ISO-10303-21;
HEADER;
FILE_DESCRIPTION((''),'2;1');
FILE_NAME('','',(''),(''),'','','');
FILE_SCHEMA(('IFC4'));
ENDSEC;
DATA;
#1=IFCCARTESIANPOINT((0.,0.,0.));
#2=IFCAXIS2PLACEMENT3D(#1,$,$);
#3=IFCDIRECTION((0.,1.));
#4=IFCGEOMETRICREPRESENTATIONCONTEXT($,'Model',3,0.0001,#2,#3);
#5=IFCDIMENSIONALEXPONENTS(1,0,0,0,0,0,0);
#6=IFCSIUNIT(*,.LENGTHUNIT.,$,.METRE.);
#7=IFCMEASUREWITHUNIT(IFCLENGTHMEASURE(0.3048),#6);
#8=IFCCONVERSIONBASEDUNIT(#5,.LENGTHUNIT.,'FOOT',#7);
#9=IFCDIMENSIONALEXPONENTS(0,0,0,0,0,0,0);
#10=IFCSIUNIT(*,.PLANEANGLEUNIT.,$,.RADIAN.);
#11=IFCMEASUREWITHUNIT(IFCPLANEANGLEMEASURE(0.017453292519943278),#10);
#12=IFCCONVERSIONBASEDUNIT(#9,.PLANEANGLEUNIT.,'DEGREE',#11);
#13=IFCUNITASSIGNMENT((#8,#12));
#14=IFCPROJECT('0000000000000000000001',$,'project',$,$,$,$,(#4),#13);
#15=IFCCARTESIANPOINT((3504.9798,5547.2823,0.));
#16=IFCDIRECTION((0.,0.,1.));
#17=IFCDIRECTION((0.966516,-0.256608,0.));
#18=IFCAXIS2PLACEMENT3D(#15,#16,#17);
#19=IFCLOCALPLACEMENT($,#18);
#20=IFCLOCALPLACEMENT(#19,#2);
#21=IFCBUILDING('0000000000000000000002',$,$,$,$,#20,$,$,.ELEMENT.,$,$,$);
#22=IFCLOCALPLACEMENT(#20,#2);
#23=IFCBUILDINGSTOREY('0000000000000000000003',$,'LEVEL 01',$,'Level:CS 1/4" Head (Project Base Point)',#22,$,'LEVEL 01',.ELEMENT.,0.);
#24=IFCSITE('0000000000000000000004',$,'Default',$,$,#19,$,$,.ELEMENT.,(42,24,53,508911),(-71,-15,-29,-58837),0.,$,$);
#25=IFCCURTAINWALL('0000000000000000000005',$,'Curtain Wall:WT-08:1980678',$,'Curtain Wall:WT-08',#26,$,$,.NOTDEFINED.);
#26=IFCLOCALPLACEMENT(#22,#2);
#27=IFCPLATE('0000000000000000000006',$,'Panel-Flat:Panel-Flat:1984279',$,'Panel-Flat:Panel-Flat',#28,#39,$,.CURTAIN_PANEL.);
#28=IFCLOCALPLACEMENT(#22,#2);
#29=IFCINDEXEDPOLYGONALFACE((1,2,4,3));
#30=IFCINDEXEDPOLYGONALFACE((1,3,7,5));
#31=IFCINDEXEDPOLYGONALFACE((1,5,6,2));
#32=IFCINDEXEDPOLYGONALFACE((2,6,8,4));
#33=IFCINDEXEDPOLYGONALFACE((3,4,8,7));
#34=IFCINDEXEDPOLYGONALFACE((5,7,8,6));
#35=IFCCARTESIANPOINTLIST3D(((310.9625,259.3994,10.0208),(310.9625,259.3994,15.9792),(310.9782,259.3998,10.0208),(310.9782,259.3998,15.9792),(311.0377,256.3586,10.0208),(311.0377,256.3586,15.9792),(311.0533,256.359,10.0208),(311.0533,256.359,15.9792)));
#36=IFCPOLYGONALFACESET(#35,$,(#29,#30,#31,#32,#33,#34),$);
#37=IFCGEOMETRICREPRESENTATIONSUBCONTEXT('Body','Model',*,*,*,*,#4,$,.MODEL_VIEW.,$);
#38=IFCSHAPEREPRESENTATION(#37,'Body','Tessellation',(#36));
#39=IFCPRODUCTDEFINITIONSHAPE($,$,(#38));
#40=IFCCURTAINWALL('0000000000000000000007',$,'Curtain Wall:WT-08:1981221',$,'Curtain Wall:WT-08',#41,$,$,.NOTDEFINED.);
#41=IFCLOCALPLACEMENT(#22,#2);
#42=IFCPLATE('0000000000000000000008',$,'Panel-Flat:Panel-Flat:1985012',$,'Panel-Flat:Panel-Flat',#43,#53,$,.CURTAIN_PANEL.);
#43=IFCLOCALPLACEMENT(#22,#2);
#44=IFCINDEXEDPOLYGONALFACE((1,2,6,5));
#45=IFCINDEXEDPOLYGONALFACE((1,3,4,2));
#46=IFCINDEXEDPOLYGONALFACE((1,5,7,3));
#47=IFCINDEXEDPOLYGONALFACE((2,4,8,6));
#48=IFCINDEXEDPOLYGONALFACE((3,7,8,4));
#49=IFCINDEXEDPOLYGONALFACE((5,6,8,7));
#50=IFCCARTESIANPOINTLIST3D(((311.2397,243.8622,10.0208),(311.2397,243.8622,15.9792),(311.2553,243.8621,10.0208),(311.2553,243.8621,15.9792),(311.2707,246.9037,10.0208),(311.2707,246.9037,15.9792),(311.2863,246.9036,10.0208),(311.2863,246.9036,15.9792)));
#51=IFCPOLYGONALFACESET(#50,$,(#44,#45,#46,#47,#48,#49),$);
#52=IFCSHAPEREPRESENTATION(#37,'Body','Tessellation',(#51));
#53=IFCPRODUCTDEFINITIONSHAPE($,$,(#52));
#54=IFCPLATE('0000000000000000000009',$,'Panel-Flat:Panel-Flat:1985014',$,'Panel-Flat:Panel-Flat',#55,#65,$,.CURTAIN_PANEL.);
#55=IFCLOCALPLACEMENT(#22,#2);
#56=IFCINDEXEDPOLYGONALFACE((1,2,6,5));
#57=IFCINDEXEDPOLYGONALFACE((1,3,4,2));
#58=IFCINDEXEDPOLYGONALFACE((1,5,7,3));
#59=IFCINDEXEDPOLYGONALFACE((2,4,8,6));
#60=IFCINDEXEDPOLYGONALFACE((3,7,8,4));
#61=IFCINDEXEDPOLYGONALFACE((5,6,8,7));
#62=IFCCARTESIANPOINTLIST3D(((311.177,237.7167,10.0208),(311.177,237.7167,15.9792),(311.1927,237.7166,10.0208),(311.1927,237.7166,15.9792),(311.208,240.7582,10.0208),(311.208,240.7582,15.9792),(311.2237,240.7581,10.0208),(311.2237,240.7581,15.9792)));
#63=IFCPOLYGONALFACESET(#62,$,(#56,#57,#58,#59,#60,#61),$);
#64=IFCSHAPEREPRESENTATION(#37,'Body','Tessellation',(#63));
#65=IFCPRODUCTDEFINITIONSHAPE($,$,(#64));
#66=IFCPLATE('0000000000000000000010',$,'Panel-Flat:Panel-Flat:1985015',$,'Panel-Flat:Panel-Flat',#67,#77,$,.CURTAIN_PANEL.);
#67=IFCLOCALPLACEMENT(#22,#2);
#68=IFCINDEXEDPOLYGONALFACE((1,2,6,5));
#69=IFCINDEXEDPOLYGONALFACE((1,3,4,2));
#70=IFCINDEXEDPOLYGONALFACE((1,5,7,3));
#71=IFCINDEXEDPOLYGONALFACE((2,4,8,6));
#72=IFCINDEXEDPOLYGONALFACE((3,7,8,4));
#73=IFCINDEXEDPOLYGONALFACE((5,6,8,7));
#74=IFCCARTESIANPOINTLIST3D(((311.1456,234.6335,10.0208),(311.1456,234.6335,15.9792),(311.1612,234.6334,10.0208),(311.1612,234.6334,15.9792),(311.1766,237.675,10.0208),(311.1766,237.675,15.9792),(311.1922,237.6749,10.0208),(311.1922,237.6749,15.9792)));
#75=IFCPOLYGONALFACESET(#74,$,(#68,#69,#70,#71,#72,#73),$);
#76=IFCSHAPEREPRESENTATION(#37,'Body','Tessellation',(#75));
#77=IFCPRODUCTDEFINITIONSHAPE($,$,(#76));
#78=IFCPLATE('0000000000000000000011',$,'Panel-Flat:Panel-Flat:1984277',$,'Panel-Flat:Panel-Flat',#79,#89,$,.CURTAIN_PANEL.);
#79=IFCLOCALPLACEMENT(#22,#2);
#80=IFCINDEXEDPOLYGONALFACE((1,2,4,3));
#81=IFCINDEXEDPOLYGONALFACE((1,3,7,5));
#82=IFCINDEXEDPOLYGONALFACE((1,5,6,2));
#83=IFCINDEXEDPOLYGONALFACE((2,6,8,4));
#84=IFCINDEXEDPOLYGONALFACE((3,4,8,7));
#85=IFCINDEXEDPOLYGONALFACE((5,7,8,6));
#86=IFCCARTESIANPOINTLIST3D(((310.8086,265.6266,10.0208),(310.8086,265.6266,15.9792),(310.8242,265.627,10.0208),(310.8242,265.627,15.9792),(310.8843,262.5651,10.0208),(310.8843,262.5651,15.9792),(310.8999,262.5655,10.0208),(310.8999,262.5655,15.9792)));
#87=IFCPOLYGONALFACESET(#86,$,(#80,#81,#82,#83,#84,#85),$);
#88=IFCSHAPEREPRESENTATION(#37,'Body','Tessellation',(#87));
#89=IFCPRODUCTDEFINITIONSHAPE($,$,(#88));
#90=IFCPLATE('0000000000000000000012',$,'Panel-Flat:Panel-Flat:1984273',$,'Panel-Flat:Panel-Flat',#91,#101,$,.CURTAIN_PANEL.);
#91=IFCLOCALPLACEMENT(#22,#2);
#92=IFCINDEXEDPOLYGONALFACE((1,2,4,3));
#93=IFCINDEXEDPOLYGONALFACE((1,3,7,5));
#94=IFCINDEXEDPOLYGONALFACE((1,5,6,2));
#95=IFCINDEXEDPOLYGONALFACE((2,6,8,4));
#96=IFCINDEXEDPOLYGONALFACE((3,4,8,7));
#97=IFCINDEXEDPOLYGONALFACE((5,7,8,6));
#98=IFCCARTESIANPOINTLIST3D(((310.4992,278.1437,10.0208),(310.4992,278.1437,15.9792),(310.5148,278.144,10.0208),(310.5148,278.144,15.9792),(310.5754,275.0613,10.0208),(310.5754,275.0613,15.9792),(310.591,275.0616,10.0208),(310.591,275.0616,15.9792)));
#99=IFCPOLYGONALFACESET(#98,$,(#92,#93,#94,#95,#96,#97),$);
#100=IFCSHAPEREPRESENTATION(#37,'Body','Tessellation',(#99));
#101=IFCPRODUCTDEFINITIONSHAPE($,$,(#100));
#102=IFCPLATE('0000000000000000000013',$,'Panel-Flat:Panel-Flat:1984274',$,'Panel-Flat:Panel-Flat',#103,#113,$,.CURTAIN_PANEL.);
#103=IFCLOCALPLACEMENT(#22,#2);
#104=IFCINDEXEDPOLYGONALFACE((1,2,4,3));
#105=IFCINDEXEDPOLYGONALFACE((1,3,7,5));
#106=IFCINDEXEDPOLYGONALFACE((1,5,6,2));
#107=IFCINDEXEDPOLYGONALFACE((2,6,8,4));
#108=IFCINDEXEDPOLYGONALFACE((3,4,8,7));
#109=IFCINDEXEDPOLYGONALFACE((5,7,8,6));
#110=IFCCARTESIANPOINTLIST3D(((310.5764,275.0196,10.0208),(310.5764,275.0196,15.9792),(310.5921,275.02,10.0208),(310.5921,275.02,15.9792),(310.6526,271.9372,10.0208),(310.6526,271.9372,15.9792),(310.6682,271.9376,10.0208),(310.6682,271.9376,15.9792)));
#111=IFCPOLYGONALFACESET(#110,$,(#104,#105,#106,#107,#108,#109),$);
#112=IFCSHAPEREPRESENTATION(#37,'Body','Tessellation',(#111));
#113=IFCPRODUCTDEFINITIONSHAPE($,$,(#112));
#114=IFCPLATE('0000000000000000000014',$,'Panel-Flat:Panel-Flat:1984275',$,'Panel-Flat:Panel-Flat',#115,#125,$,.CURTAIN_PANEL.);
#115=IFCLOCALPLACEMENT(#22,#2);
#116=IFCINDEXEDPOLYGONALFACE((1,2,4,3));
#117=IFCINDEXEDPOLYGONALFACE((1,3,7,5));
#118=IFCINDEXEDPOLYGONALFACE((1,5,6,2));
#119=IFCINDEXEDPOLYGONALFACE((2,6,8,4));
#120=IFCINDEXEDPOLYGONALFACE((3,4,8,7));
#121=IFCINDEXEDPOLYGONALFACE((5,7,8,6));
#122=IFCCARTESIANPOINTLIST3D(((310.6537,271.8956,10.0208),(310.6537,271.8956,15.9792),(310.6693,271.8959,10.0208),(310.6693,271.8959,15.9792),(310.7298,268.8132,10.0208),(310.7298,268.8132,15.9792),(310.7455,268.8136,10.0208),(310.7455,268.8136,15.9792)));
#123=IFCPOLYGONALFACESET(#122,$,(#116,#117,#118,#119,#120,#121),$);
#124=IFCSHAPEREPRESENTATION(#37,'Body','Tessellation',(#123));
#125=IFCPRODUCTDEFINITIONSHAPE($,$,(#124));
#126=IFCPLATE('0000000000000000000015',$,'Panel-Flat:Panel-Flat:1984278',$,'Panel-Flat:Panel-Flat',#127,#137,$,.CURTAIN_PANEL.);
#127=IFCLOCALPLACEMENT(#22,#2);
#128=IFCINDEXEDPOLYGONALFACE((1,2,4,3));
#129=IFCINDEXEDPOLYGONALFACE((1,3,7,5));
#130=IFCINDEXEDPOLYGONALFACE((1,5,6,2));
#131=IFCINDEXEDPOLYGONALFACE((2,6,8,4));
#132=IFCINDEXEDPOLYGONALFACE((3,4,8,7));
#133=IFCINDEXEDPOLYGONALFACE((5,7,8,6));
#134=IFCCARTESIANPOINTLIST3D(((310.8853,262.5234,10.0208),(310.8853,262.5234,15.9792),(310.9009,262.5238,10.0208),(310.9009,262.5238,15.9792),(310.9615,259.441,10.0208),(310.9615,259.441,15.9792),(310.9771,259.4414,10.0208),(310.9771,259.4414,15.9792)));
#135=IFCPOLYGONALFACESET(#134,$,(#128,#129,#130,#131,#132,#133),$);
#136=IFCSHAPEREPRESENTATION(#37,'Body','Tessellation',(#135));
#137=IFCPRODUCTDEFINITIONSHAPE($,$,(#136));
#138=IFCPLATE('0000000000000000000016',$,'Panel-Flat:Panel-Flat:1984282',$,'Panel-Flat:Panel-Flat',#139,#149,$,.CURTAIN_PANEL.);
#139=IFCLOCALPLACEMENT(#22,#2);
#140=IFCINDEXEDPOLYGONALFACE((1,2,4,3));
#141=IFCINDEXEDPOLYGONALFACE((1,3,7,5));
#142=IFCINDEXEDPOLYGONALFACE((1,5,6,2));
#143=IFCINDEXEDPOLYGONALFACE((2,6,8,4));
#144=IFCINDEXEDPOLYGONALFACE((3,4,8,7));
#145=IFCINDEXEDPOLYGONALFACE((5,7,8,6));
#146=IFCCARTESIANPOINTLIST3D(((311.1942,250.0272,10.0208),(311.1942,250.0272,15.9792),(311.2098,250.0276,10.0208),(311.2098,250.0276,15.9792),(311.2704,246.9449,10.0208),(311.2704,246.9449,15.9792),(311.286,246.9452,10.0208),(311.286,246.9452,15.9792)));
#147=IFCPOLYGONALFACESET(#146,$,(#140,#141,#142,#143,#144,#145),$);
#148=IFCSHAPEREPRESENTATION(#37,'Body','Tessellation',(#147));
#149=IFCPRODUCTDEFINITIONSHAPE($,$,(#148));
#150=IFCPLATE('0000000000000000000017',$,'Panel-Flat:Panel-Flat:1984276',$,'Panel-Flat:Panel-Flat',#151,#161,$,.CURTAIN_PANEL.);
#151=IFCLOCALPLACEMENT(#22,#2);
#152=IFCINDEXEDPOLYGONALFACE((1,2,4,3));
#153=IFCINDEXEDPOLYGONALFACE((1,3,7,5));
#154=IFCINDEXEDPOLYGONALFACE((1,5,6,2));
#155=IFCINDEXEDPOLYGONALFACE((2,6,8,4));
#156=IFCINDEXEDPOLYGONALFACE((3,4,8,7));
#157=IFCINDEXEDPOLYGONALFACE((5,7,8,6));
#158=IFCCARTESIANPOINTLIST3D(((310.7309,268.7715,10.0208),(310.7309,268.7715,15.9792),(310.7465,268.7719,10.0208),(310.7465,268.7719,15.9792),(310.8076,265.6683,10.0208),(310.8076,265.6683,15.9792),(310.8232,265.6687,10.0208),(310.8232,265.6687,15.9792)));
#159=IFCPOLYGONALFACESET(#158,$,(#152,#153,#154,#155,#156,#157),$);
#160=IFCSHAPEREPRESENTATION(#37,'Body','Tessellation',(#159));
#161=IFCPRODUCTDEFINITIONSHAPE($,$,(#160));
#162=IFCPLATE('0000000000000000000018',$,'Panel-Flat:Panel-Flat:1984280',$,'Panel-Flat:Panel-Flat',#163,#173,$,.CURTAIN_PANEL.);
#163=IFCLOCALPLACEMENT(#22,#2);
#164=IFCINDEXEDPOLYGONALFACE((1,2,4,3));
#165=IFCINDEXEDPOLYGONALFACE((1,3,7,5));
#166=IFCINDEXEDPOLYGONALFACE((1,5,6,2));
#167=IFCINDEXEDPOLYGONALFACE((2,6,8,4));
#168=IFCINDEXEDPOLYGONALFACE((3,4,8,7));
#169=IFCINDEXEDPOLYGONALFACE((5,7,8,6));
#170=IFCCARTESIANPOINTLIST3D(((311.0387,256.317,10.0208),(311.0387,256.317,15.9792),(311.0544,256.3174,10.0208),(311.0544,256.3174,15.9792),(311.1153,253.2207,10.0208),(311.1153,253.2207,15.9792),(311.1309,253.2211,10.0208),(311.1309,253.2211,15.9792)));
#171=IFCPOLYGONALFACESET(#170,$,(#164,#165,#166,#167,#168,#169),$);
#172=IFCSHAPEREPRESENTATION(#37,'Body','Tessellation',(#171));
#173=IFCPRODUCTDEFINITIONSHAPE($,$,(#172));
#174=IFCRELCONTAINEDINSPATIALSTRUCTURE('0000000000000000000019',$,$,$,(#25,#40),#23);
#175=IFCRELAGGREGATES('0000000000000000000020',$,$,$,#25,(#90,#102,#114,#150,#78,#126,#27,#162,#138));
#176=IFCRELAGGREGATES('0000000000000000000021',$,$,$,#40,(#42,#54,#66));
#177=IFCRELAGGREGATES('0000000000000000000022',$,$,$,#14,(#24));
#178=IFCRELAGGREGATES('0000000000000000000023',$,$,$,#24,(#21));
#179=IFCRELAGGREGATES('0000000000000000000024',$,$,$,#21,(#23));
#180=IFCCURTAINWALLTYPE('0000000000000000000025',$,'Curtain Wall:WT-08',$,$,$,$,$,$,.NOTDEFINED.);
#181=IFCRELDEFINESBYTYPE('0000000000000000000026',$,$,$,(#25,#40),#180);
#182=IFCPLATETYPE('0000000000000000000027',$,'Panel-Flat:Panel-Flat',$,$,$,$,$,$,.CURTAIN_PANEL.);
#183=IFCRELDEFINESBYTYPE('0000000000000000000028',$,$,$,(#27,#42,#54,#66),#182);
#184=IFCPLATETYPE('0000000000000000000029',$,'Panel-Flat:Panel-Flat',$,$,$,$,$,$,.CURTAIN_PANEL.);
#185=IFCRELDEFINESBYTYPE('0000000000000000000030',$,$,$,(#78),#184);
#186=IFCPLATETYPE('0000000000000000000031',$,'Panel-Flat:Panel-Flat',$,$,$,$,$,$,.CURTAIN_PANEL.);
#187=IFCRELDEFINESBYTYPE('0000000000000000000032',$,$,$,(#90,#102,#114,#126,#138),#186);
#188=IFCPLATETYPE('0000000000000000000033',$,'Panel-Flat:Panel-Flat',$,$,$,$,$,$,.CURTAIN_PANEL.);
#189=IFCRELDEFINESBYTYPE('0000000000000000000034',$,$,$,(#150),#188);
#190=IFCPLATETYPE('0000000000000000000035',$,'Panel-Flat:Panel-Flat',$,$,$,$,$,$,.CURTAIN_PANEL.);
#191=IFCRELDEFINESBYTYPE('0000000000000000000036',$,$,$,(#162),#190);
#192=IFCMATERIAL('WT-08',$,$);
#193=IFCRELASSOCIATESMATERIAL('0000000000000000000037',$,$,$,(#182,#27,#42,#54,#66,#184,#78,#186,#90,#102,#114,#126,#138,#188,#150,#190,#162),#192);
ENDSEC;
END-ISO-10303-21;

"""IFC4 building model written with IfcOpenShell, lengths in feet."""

from ifc_helpers import new_model, entity, si_unit, converted_unit, direction, frame, origin, place, context, subcontext, project, spatial, indexed_curve, outline, extrude, source, transform, mapped, material, type_object, type_shapes, element, aggregate, save


model = new_model("IFC4")

# Units and contexts
model_context = context("Model", 3, precision=0.0001, world=origin(), true_north=direction((0.0, 1.0)))
body_context = subcontext(model_context, "Body", "Model", "MODEL_VIEW")
ifc_project = project(units=[converted_unit("LENGTHUNIT", "FOOT", entity("IfcLengthMeasure", 0.3048), si_unit("LENGTHUNIT", "METRE"), dimensions=[1, 0, 0, 0, 0, 0, 0]), converted_unit("PLANEANGLEUNIT", "DEGREE", entity("IfcPlaneAngleMeasure", 0.017453292519943278), si_unit("PLANEANGLEUNIT", "RADIAN"), dimensions=[0, 0, 0, 0, 0, 0, 0])], contexts=[model_context])

# Site, building, storey
site_placement = place(None, frame((3504.9798, 5547.2823, 0.0), z_axis=(0.0, 0.0, 1.0), x_axis=(0.966516, -0.256608, 0.0)))
site = spatial("IfcSite", under=ifc_project, at=site_placement, Name="Default", CompositionType="ELEMENT", RefLatitude=(42, 24, 53, 508911), RefLongitude=(-71, -15, -29, -58837), RefElevation=0.0)
building_placement = place(site_placement, origin())
building = spatial("IfcBuilding", under=site, at=building_placement, CompositionType="ELEMENT")
storey_placement = place(building_placement, origin())
storey = spatial("IfcBuildingStorey", under=building, at=storey_placement, Name="LEVEL 01", ObjectType="Level:CS 1/4\" Head (Project Base Point)", LongName="LEVEL 01", CompositionType="ELEMENT", Elevation=0.0)

# Curtain walls, plates
curtain_wall_type_1 = type_object("IfcCurtainWallType", Name="Curtain Wall:WT-08", PredefinedType="NOTDEFINED")
curtain_wall_1_placement = place(storey_placement, origin())
curtain_wall_1 = element("IfcCurtainWall", 1, at=curtain_wall_1_placement, inside=storey, type_object=curtain_wall_type_1, Name="Curtain Wall:WT-08:1980678", ObjectType="Curtain Wall:WT-08", PredefinedType="NOTDEFINED")
ifc_material_1 = material(Name="WT-08")
plate_type_1 = type_object("IfcPlateType", Name="Panel-Flat:Panel-Flat", PredefinedType="CURTAIN_PANEL", material=ifc_material_1)
shared_shape_1 = source(origin(), body_context, "Body", "SweptSolid", [
    extrude(outline(indexed_curve([(-0.0078, -1.5208), (0.0078, -1.5208), (0.0078, 1.5208), (-0.0078, 1.5208), (-0.0078, -1.5208)], self_intersect=False)), frame((0.0, -0.0078, 0.0208), z_axis=(0.0, 0.0, 1.0), x_axis=(0.0, -1.0, 0.0)), (0.0, 0.0, 1.0), 5.9583),
])
type_shapes(plate_type_1, [shared_shape_1])
plate_1_placement = place(curtain_wall_1_placement, frame((311.0157, 257.8794, 10.0), z_axis=(0.0, 0.0, 1.0), x_axis=(0.024711, -0.999695, 0.0)))
plate_1 = element("IfcPlate", 2, at=plate_1_placement, type_object=plate_type_1, material=ifc_material_1, Name="Panel-Flat:Panel-Flat:1984279", ObjectType="Panel-Flat:Panel-Flat", PredefinedType="CURTAIN_PANEL", context=body_context, shape_type="MappedRepresentation", body=[
    mapped(shared_shape_1, transform((0.0, 0.0, 0.0), scale=1.0)),
])
curtain_wall_2_placement = place(storey_placement, origin())
curtain_wall_2 = element("IfcCurtainWall", 3, at=curtain_wall_2_placement, inside=storey, type_object=curtain_wall_type_1, Name="Curtain Wall:WT-08:1981221", ObjectType="Curtain Wall:WT-08", PredefinedType="NOTDEFINED")
plate_2_placement = place(curtain_wall_2_placement, frame((311.2708, 245.3828, 10.0), z_axis=(0.0, 0.0, 1.0), x_axis=(-0.010193, -0.999948, 0.0)))
plate_2 = element("IfcPlate", 4, at=plate_2_placement, type_object=plate_type_1, material=ifc_material_1, Name="Panel-Flat:Panel-Flat:1985012", ObjectType="Panel-Flat:Panel-Flat", PredefinedType="CURTAIN_PANEL", context=body_context, shape_type="MappedRepresentation", body=[
    mapped(shared_shape_1, transform((0.0, 0.0, 0.0), scale=1.0)),
])
plate_3_placement = place(curtain_wall_2_placement, frame((311.2082, 239.2373, 10.0), z_axis=(0.0, 0.0, 1.0), x_axis=(-0.010193, -0.999948, 0.0)))
plate_3 = element("IfcPlate", 5, at=plate_3_placement, type_object=plate_type_1, material=ifc_material_1, Name="Panel-Flat:Panel-Flat:1985014", ObjectType="Panel-Flat:Panel-Flat", PredefinedType="CURTAIN_PANEL", context=body_context, shape_type="MappedRepresentation", body=[
    mapped(shared_shape_1, transform((0.0, 0.0, 0.0), scale=1.0)),
])
plate_4_placement = place(curtain_wall_2_placement, frame((311.1767, 236.1541, 10.0), z_axis=(0.0, 0.0, 1.0), x_axis=(-0.010193, -0.999948, 0.0)))
plate_4 = element("IfcPlate", 6, at=plate_4_placement, type_object=plate_type_1, material=ifc_material_1, Name="Panel-Flat:Panel-Flat:1985015", ObjectType="Panel-Flat:Panel-Flat", PredefinedType="CURTAIN_PANEL", context=body_context, shape_type="MappedRepresentation", body=[
    mapped(shared_shape_1, transform((0.0, 0.0, 0.0), scale=1.0)),
])

# Plates
plate_type_2 = type_object("IfcPlateType", Name="Panel-Flat:Panel-Flat", PredefinedType="CURTAIN_PANEL", material=ifc_material_1)
shared_shape_2 = source(origin(), body_context, "Body", "SweptSolid", [
    extrude(outline(indexed_curve([(-0.0078, -1.5313), (0.0078, -1.5313), (0.0078, 1.5313), (-0.0078, 1.5313), (-0.0078, -1.5313)], self_intersect=False)), frame((0.0, -0.0078, 0.0208), z_axis=(0.0, 0.0, 1.0), x_axis=(0.0, -1.0, 0.0)), (0.0, 0.0, 1.0), 5.9583),
])
type_shapes(plate_type_2, [shared_shape_2])
plate_5_placement = place(curtain_wall_1_placement, frame((310.8621, 264.0962, 10.0), z_axis=(0.0, 0.0, 1.0), x_axis=(0.024711, -0.999695, 0.0)))
plate_5 = element("IfcPlate", 7, at=plate_5_placement, type_object=plate_type_2, material=ifc_material_1, Name="Panel-Flat:Panel-Flat:1984277", ObjectType="Panel-Flat:Panel-Flat", PredefinedType="CURTAIN_PANEL", context=body_context, shape_type="MappedRepresentation", body=[
    mapped(shared_shape_2, transform((0.0, 0.0, 0.0), scale=1.0)),
])
plate_type_3 = type_object("IfcPlateType", Name="Panel-Flat:Panel-Flat", PredefinedType="CURTAIN_PANEL", material=ifc_material_1)
shared_shape_3 = source(origin(), body_context, "Body", "SweptSolid", [
    extrude(outline(indexed_curve([(-0.0078, -1.5417), (0.0078, -1.5417), (0.0078, 1.5417), (-0.0078, 1.5417), (-0.0078, -1.5417)], self_intersect=False)), frame((0.0, -0.0078, 0.0208), z_axis=(0.0, 0.0, 1.0), x_axis=(0.0, -1.0, 0.0)), (0.0, 0.0, 1.0), 5.9583),
])
type_shapes(plate_type_3, [shared_shape_3])
plate_6_placement = place(curtain_wall_1_placement, frame((310.5529, 276.6028, 10.0), z_axis=(0.0, 0.0, 1.0), x_axis=(0.024711, -0.999695, 0.0)))
plate_6 = element("IfcPlate", 8, at=plate_6_placement, type_object=plate_type_3, material=ifc_material_1, Name="Panel-Flat:Panel-Flat:1984273", ObjectType="Panel-Flat:Panel-Flat", PredefinedType="CURTAIN_PANEL", context=body_context, shape_type="MappedRepresentation", body=[
    mapped(shared_shape_3, transform((0.0, 0.0, 0.0), scale=1.0)),
])
plate_7_placement = place(curtain_wall_1_placement, frame((310.6301, 273.4788, 10.0), z_axis=(0.0, 0.0, 1.0), x_axis=(0.024711, -0.999695, 0.0)))
plate_7 = element("IfcPlate", 9, at=plate_7_placement, type_object=plate_type_3, material=ifc_material_1, Name="Panel-Flat:Panel-Flat:1984274", ObjectType="Panel-Flat:Panel-Flat", PredefinedType="CURTAIN_PANEL", context=body_context, shape_type="MappedRepresentation", body=[
    mapped(shared_shape_3, transform((0.0, 0.0, 0.0), scale=1.0)),
])
plate_8_placement = place(curtain_wall_1_placement, frame((310.7074, 270.3548, 10.0), z_axis=(0.0, 0.0, 1.0), x_axis=(0.024711, -0.999695, 0.0)))
plate_8 = element("IfcPlate", 10, at=plate_8_placement, type_object=plate_type_3, material=ifc_material_1, Name="Panel-Flat:Panel-Flat:1984275", ObjectType="Panel-Flat:Panel-Flat", PredefinedType="CURTAIN_PANEL", context=body_context, shape_type="MappedRepresentation", body=[
    mapped(shared_shape_3, transform((0.0, 0.0, 0.0), scale=1.0)),
])
plate_9_placement = place(curtain_wall_1_placement, frame((310.939, 260.9826, 10.0), z_axis=(0.0, 0.0, 1.0), x_axis=(0.024711, -0.999695, 0.0)))
plate_9 = element("IfcPlate", 11, at=plate_9_placement, type_object=plate_type_3, material=ifc_material_1, Name="Panel-Flat:Panel-Flat:1984278", ObjectType="Panel-Flat:Panel-Flat", PredefinedType="CURTAIN_PANEL", context=body_context, shape_type="MappedRepresentation", body=[
    mapped(shared_shape_3, transform((0.0, 0.0, 0.0), scale=1.0)),
])
plate_10_placement = place(curtain_wall_1_placement, frame((311.2479, 248.4864, 10.0), z_axis=(0.0, 0.0, 1.0), x_axis=(0.024711, -0.999695, 0.0)))
plate_10 = element("IfcPlate", 12, at=plate_10_placement, type_object=plate_type_3, material=ifc_material_1, Name="Panel-Flat:Panel-Flat:1984282", ObjectType="Panel-Flat:Panel-Flat", PredefinedType="CURTAIN_PANEL", context=body_context, shape_type="MappedRepresentation", body=[
    mapped(shared_shape_3, transform((0.0, 0.0, 0.0), scale=1.0)),
])
plate_type_4 = type_object("IfcPlateType", Name="Panel-Flat:Panel-Flat", PredefinedType="CURTAIN_PANEL", material=ifc_material_1)
shared_shape_4 = source(origin(), body_context, "Body", "SweptSolid", [
    extrude(outline(indexed_curve([(-0.0078, -1.5521), (0.0078, -1.5521), (0.0078, 1.5521), (-0.0078, 1.5521), (-0.0078, -1.5521)], self_intersect=False)), frame((0.0, -0.0078, 0.0208), z_axis=(0.0, 0.0, 1.0), x_axis=(0.0, -1.0, 0.0)), (0.0, 0.0, 1.0), 5.9583),
])
type_shapes(plate_type_4, [shared_shape_4])
plate_11_placement = place(curtain_wall_1_placement, frame((310.7848, 267.2203, 10.0), z_axis=(0.0, 0.0, 1.0), x_axis=(0.024711, -0.999695, 0.0)))
plate_11 = element("IfcPlate", 13, at=plate_11_placement, type_object=plate_type_4, material=ifc_material_1, Name="Panel-Flat:Panel-Flat:1984276", ObjectType="Panel-Flat:Panel-Flat", PredefinedType="CURTAIN_PANEL", context=body_context, shape_type="MappedRepresentation", body=[
    mapped(shared_shape_4, transform((0.0, 0.0, 0.0), scale=1.0)),
])
plate_type_5 = type_object("IfcPlateType", Name="Panel-Flat:Panel-Flat", PredefinedType="CURTAIN_PANEL", material=ifc_material_1)
shared_shape_5 = source(origin(), body_context, "Body", "SweptSolid", [
    extrude(outline(indexed_curve([(-0.0078, -1.5486), (0.0078, -1.5486), (0.0078, 1.5486), (-0.0078, 1.5486), (-0.0078, -1.5486)], self_intersect=False)), frame((0.0, -0.0078, 0.0208), z_axis=(0.0, 0.0, 1.0), x_axis=(0.0, -1.0, 0.0)), (0.0, 0.0, 1.0), 5.9583),
])
type_shapes(plate_type_5, [shared_shape_5])
plate_12_placement = place(curtain_wall_1_placement, frame((311.0926, 254.7692, 10.0), z_axis=(0.0, 0.0, 1.0), x_axis=(0.024711, -0.999695, 0.0)))
plate_12 = element("IfcPlate", 14, at=plate_12_placement, type_object=plate_type_5, material=ifc_material_1, Name="Panel-Flat:Panel-Flat:1984280", ObjectType="Panel-Flat:Panel-Flat", PredefinedType="CURTAIN_PANEL", context=body_context, shape_type="MappedRepresentation", body=[
    mapped(shared_shape_5, transform((0.0, 0.0, 0.0), scale=1.0)),
])
aggregate(curtain_wall_1, [plate_6, plate_7, plate_8, plate_11, plate_5, plate_9, plate_1, plate_12, plate_10])
aggregate(curtain_wall_2, [plate_2, plate_3, plate_4])

save(model, "model.ifc")
